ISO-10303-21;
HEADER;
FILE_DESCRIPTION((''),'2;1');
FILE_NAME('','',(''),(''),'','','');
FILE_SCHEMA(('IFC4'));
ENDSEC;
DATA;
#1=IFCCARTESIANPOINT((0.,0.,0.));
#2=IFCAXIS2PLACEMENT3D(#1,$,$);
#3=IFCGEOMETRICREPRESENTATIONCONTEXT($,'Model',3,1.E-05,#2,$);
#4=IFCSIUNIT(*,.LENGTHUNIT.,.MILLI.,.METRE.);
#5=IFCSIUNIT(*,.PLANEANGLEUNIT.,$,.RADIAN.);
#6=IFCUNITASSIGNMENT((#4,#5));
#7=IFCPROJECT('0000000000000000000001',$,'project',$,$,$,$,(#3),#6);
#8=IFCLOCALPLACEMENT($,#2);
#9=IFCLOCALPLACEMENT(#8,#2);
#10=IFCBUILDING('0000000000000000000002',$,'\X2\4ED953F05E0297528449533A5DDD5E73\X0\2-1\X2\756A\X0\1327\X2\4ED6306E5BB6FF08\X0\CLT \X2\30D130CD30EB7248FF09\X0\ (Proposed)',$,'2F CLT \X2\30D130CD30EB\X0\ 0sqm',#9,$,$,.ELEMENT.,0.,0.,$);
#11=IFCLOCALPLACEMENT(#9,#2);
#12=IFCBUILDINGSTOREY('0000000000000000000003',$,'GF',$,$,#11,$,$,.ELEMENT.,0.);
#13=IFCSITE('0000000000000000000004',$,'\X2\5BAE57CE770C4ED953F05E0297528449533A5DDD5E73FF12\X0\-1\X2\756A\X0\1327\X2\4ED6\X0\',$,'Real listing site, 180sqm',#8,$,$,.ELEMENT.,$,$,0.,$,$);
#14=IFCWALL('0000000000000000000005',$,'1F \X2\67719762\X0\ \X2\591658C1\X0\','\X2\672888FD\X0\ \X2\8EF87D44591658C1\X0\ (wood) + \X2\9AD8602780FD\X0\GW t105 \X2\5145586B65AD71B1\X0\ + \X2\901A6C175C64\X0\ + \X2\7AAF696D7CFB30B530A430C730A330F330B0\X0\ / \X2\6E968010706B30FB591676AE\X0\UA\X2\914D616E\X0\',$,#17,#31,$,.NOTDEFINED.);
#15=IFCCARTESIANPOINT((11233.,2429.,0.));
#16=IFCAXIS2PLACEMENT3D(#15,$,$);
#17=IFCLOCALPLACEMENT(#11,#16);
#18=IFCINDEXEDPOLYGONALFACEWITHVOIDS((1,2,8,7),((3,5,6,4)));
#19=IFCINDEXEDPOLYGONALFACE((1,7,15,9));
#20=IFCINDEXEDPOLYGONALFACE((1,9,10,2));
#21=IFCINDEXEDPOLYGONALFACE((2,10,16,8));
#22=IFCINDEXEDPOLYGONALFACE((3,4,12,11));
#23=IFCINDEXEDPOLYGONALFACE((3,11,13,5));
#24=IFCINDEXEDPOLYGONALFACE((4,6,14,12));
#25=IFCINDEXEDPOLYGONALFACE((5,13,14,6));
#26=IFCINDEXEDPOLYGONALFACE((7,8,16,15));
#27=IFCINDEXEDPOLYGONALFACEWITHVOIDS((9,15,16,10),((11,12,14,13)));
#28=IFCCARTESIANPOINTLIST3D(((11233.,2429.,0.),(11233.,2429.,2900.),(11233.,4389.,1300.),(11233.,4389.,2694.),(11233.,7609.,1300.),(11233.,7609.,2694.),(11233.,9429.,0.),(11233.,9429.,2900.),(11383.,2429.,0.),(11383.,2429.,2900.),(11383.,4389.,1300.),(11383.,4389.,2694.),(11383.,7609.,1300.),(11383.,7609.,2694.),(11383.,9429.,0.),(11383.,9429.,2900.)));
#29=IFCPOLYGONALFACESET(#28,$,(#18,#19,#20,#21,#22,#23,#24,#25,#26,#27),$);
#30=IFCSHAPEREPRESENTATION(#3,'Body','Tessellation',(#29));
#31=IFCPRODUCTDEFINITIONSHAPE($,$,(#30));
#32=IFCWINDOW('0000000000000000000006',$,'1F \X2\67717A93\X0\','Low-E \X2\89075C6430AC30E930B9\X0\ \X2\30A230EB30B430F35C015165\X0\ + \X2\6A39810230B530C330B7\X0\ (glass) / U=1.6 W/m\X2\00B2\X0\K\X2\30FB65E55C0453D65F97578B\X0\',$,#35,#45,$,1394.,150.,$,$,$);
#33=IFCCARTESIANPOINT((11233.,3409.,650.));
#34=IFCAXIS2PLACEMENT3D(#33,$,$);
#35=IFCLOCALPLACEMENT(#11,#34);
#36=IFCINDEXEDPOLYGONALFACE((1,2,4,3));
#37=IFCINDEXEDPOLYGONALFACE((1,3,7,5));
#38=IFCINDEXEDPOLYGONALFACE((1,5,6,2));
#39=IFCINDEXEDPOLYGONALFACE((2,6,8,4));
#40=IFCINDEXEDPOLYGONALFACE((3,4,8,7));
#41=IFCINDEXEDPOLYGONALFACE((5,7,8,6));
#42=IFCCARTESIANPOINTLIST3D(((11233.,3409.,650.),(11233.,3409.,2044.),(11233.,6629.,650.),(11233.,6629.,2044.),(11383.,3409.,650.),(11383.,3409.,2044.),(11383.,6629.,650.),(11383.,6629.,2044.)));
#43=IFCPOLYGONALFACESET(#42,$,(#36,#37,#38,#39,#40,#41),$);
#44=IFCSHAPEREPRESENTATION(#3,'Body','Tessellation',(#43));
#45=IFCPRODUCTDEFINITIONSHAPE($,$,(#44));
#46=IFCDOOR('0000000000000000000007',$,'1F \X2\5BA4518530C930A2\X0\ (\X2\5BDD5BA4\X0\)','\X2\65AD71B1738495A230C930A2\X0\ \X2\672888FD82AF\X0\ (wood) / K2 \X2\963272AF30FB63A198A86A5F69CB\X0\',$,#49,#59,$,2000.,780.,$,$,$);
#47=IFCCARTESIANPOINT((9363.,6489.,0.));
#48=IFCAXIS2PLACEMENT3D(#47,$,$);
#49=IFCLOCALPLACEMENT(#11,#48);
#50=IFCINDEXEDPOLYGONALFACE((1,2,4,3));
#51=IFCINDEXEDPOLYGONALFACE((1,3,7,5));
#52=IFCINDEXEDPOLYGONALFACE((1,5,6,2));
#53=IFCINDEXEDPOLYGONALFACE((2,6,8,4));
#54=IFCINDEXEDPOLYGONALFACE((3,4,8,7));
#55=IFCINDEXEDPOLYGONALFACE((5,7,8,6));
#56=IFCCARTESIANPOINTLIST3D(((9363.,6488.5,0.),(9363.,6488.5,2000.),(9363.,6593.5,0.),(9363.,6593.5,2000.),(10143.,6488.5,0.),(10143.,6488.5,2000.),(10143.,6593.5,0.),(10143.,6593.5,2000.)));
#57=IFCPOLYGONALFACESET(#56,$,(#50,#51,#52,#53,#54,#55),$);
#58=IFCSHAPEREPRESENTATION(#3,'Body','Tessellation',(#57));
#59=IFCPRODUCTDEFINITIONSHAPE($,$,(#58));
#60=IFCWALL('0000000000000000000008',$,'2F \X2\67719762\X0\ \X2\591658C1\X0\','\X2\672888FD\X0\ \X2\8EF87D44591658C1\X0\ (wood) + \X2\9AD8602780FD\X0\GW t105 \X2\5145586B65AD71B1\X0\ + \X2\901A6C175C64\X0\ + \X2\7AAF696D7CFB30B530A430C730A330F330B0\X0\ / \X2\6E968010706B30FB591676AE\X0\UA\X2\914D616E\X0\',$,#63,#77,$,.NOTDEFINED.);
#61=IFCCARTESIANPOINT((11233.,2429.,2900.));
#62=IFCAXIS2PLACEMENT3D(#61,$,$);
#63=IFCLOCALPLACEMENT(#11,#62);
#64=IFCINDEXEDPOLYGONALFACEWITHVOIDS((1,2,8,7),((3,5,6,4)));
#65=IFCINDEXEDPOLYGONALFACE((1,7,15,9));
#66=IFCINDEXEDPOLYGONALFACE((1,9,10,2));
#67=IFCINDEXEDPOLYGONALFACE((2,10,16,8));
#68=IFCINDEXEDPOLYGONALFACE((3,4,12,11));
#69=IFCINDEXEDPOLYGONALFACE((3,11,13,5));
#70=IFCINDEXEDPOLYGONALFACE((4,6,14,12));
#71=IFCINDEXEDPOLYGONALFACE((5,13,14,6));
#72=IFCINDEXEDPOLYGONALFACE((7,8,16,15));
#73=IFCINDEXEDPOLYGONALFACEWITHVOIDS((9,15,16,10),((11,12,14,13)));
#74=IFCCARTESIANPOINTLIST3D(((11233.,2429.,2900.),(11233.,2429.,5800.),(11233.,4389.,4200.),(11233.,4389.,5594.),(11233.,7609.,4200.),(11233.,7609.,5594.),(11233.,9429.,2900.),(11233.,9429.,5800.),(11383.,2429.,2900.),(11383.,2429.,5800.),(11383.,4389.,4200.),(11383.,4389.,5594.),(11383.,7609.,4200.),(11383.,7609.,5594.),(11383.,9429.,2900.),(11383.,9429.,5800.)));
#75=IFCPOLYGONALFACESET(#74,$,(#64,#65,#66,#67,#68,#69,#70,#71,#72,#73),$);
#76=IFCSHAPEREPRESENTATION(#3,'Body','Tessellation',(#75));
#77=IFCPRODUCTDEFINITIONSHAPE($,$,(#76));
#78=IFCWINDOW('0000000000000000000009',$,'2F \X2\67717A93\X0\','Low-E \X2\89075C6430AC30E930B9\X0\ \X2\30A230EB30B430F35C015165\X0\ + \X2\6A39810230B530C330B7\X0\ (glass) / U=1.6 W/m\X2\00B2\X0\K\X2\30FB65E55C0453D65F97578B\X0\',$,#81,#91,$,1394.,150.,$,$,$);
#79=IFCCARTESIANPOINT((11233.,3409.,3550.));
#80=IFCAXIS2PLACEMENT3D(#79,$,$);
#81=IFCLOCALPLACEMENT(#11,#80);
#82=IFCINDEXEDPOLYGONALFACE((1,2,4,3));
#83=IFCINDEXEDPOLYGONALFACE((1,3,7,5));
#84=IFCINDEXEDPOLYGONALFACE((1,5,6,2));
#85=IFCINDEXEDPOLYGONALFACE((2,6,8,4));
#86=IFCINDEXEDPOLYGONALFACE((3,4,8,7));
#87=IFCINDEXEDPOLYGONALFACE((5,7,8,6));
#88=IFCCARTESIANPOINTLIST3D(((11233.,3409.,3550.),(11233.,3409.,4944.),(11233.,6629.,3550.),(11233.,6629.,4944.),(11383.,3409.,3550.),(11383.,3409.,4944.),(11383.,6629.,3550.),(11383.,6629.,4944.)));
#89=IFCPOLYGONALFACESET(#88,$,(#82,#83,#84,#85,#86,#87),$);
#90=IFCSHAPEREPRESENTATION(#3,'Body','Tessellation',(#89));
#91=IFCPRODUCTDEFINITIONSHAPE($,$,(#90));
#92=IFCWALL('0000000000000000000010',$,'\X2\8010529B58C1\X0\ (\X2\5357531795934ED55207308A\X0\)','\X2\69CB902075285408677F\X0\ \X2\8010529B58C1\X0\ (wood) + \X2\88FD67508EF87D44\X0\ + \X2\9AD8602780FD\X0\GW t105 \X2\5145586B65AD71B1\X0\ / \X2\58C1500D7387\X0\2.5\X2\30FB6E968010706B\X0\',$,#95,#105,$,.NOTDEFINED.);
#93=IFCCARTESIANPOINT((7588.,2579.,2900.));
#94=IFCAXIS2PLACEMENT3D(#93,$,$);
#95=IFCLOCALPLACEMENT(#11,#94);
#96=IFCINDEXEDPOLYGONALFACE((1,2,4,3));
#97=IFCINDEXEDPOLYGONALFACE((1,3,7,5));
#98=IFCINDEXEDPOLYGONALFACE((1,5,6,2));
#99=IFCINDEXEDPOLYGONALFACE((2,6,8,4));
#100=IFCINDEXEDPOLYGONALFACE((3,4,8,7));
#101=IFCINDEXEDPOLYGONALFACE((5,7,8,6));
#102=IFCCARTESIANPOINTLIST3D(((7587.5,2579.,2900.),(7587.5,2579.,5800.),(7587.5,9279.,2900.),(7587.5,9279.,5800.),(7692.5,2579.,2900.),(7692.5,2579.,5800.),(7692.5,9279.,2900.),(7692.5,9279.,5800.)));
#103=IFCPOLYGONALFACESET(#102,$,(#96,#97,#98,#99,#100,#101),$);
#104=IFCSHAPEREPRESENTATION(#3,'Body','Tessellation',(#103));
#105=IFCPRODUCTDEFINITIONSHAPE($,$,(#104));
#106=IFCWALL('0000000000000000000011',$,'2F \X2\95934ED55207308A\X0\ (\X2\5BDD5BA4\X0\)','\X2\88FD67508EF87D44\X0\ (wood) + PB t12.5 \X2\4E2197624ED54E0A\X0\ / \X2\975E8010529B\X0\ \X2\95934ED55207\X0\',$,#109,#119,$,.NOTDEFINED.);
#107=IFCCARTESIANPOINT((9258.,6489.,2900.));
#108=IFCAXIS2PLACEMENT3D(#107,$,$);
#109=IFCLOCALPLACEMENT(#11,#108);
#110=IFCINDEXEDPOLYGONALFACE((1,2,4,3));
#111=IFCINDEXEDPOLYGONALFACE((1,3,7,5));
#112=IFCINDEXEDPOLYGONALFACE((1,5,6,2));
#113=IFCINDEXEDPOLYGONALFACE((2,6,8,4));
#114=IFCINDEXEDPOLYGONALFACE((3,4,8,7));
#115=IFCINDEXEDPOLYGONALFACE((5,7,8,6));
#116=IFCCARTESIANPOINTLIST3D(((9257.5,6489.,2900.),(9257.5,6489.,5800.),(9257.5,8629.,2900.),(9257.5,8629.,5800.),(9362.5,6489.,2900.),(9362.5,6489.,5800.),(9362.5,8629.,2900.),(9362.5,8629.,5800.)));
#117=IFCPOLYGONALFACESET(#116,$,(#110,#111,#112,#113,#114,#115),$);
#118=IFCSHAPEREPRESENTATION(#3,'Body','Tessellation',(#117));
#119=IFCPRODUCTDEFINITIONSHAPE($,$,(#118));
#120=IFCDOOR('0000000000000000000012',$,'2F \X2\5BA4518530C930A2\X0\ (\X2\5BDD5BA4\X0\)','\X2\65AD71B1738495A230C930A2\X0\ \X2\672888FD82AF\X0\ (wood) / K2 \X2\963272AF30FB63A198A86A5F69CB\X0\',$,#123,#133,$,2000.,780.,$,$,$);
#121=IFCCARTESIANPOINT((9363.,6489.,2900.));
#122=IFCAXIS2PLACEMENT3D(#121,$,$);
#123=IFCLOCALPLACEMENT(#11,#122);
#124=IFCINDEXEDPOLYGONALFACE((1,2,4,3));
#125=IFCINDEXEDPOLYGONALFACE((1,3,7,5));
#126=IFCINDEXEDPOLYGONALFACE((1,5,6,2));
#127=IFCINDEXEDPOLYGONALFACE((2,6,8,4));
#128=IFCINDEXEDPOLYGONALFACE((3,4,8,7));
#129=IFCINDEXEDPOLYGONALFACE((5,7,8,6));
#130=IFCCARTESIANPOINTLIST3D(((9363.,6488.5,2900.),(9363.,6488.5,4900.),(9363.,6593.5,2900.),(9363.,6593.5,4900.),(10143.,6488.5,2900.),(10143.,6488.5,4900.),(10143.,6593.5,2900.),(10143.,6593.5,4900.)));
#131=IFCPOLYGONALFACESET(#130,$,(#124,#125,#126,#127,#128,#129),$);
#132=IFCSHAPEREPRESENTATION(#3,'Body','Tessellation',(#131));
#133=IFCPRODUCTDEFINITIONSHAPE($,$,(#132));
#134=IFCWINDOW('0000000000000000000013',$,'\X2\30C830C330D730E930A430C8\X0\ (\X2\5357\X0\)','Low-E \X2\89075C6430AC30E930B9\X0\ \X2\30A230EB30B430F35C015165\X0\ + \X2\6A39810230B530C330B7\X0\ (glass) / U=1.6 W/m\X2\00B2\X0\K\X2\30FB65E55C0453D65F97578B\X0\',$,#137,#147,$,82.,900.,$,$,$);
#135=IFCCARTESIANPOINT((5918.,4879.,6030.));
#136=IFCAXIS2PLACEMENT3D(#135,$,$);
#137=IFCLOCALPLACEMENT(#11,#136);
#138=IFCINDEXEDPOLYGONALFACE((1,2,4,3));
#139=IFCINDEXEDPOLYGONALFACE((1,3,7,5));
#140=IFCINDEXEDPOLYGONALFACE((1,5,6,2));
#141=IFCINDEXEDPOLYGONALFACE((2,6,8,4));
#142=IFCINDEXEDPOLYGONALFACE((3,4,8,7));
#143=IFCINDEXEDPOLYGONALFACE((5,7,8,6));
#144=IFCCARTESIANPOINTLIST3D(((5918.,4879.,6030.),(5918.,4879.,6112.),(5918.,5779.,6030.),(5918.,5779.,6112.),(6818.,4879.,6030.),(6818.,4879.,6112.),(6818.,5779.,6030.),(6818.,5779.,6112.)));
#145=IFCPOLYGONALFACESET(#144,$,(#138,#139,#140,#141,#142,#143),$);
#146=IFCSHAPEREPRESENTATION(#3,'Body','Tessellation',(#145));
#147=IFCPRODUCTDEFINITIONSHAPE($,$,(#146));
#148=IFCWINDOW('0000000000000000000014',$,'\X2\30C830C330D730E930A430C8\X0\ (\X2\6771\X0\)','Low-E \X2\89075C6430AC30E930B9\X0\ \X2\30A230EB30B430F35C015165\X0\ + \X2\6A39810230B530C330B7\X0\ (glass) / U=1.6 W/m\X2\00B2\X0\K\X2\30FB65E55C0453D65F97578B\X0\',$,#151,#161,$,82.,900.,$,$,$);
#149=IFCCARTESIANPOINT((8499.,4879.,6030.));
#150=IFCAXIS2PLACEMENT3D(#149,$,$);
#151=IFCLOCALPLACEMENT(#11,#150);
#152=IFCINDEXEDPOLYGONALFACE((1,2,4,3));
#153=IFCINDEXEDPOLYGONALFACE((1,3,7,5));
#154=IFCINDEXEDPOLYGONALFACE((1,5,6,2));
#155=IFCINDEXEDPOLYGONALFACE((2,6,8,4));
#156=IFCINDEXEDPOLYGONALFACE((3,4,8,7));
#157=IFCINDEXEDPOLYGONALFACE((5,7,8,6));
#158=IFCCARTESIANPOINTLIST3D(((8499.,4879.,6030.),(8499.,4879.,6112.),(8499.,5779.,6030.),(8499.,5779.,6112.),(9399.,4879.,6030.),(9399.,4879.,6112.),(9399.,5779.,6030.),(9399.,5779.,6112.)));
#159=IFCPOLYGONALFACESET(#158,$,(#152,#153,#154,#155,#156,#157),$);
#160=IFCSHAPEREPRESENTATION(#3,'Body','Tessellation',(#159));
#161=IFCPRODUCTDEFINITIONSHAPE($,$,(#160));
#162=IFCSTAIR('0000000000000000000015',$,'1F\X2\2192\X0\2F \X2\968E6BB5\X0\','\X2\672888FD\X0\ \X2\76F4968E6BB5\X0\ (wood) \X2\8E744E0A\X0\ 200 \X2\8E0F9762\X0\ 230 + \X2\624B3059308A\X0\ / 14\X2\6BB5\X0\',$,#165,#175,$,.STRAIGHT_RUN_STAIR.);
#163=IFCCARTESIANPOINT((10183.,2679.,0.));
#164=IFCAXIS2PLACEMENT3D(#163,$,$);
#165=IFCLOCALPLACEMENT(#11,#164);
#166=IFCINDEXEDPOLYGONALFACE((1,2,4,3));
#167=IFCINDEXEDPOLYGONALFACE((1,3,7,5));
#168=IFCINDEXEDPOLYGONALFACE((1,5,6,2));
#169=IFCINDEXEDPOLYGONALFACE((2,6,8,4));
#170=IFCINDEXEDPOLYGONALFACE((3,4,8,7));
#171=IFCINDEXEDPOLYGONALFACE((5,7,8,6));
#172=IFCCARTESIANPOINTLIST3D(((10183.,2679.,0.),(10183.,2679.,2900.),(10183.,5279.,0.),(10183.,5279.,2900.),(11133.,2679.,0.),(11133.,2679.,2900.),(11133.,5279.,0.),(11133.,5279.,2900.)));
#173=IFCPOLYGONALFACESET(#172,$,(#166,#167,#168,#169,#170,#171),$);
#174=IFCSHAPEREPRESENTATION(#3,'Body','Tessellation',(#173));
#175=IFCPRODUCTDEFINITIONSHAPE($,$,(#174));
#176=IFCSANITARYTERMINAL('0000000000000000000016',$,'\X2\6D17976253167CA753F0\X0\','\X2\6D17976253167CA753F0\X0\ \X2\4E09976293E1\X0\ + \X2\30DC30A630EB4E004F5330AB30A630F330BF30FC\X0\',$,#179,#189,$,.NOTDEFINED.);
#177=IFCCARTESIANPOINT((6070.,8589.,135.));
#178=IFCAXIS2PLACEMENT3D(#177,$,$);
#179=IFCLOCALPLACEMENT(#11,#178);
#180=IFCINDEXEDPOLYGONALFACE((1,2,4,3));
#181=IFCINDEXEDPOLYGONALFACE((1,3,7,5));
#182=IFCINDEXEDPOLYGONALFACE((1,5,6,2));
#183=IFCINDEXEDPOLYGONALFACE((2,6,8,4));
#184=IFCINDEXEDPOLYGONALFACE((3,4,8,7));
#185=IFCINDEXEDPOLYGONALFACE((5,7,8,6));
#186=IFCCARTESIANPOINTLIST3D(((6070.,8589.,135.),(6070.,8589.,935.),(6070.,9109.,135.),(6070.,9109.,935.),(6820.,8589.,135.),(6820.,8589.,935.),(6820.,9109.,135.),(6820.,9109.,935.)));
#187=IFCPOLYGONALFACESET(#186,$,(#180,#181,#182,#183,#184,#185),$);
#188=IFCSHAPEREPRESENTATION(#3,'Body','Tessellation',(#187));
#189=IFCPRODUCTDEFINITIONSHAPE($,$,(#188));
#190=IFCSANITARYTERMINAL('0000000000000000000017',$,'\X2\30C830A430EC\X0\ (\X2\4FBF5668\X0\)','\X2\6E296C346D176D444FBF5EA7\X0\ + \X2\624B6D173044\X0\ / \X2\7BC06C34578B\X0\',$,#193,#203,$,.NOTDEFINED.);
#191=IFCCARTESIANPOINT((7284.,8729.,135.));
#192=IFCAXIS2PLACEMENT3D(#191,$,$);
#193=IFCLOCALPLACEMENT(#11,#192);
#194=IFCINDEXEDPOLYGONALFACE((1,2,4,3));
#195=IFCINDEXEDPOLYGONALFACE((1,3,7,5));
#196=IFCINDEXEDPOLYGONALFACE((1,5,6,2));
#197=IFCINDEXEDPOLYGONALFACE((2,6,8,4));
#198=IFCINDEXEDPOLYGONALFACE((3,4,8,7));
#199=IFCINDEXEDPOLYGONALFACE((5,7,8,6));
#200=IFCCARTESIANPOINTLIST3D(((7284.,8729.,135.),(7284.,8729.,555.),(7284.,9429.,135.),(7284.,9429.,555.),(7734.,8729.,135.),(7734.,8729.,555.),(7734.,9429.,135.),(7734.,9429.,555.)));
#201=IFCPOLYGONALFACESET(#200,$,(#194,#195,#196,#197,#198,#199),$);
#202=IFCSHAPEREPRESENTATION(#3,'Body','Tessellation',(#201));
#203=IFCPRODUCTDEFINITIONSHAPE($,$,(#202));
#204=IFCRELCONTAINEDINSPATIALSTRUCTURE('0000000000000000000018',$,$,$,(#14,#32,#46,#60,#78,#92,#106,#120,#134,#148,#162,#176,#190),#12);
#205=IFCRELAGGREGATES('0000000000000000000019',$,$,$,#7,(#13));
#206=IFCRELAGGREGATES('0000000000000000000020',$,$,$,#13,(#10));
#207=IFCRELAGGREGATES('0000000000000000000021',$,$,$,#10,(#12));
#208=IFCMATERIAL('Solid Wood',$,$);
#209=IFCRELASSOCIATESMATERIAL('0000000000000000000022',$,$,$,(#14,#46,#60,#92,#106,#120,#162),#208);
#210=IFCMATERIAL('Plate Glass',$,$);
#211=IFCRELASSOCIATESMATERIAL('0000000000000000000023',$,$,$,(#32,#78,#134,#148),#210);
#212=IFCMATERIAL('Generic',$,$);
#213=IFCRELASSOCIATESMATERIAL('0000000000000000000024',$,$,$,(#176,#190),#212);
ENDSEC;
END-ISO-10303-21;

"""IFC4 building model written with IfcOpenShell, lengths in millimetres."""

from ifc_helpers import new_model, si_unit, frame, frame_2d, origin, place, context, project, spatial, rectangle, extrude, material, element, fill, save


model = new_model("IFC4")

# Units and contexts
model_context = context("Model", 3, precision=1e-05, world=origin())
ifc_project = project(units=[si_unit("LENGTHUNIT", "METRE", prefix="MILLI"), si_unit("PLANEANGLEUNIT", "RADIAN")], contexts=[model_context])

# Site, building, storey
site_placement = place(None, origin())
site = spatial("IfcSite", under=ifc_project, at=site_placement, Name="宮城県仙台市青葉区川平２-1番1327他", ObjectType="Real listing site, 180sqm", CompositionType="ELEMENT", RefElevation=0.0)
building_placement = place(site_placement, origin())
building = spatial("IfcBuilding", under=site, at=building_placement, Name="仙台市青葉区川平2-1番1327他の家（CLT パネル版） (Proposed)", ObjectType="2F CLT パネル 0sqm", CompositionType="ELEMENT", ElevationOfRefHeight=0.0, ElevationOfTerrain=0.0)
storey_placement = place(building_placement, origin())
storey = spatial("IfcBuildingStorey", under=building, at=storey_placement, Name="GF", CompositionType="ELEMENT", Elevation=0.0)

# Wall, opening, window
ifc_material_1 = material(Name="Solid Wood")
wall_1_placement = place(storey_placement, frame((11233.0, 2429.0, 0.0)))
wall_1 = element("IfcWall", 1, at=wall_1_placement, inside=storey, material=ifc_material_1, Name="1F 東面 外壁", Description="木製 軸組外壁 (wood) + 高性能GW t105 充填断熱 + 通気層 + 窯業系サイディング / 準耐火・外皮UA配慮", PredefinedType="NOTDEFINED", context=model_context, shape_type="SweptSolid", body=[
    extrude(rectangle(XDim=150.0, YDim=7000.0, at=frame_2d((75.0, 3500.0))), frame((11233.0, 2429.0, 0.0)), (0.0, 0.0, 1.0), 2900.0),
])
opening_1_placement = place(storey_placement, frame((11233.0, 3409.0, 650.0)))
opening_1 = element("IfcOpeningElement", 2, at=opening_1_placement, cuts=wall_1, PredefinedType="NOTDEFINED", context=model_context, shape_type="SweptSolid", body=[
    extrude(rectangle(XDim=150.0, YDim=3220.0, at=frame_2d((75.0, 1610.0))), frame((11233.0, 3409.0, 650.0)), (0.0, 0.0, 1.0), 1394.0),
])
ifc_material_2 = material(Name="Plate Glass")
window_1_placement = place(storey_placement, frame((11233.0, 3409.0, 650.0)))
window_1 = element("IfcWindow", 3, at=window_1_placement, inside=storey, material=ifc_material_2, Name="1F 東窓", Description="Low-E 複層ガラス アルゴン封入 + 樹脂サッシ (glass) / U=1.6 W/m²K・日射取得型", OverallHeight=1394.0, OverallWidth=150.0, context=model_context, shape_type="SweptSolid", body=[
    extrude(rectangle(XDim=150.0, YDim=3220.0, at=frame_2d((75.0, 1610.0))), frame((11233.0, 3409.0, 650.0)), (0.0, 0.0, 1.0), 1394.0),
])
fill(opening_1, window_1)

# Door
door_1_placement = place(storey_placement, frame((9363.0, 6489.0, 0.0)))
element("IfcDoor", 4, at=door_1_placement, inside=storey, material=ifc_material_1, Name="1F 室内ドア (寝室)", Description="断熱玄関ドア 木製芯 (wood) / K2 防犯・採風機構", OverallHeight=2000.0, OverallWidth=780.0, context=model_context, shape_type="SweptSolid", body=[
    extrude(rectangle(XDim=780.0, YDim=105.0, at=frame_2d((390.0, 52.0))), frame((9363.0, 6489.0, 0.0)), (0.0, 0.0, 1.0), 2000.0),
])

# Wall, opening, window
wall_2_placement = place(storey_placement, frame((11233.0, 2429.0, 2900.0)))
wall_2 = element("IfcWall", 5, at=wall_2_placement, inside=storey, material=ifc_material_1, Name="2F 東面 外壁", Description="木製 軸組外壁 (wood) + 高性能GW t105 充填断熱 + 通気層 + 窯業系サイディング / 準耐火・外皮UA配慮", PredefinedType="NOTDEFINED", context=model_context, shape_type="SweptSolid", body=[
    extrude(rectangle(XDim=150.0, YDim=7000.0, at=frame_2d((75.0, 3500.0))), frame((11233.0, 2429.0, 2900.0)), (0.0, 0.0, 1.0), 2900.0),
])
opening_2_placement = place(storey_placement, frame((11233.0, 3409.0, 3550.0)))
opening_2 = element("IfcOpeningElement", 6, at=opening_2_placement, cuts=wall_2, PredefinedType="NOTDEFINED", context=model_context, shape_type="SweptSolid", body=[
    extrude(rectangle(XDim=150.0, YDim=3220.0, at=frame_2d((75.0, 1610.0))), frame((11233.0, 3409.0, 3550.0)), (0.0, 0.0, 1.0), 1394.0),
])
window_2_placement = place(storey_placement, frame((11233.0, 3409.0, 3550.0)))
window_2 = element("IfcWindow", 7, at=window_2_placement, inside=storey, material=ifc_material_2, Name="2F 東窓", Description="Low-E 複層ガラス アルゴン封入 + 樹脂サッシ (glass) / U=1.6 W/m²K・日射取得型", OverallHeight=1394.0, OverallWidth=150.0, context=model_context, shape_type="SweptSolid", body=[
    extrude(rectangle(XDim=150.0, YDim=3220.0, at=frame_2d((75.0, 1610.0))), frame((11233.0, 3409.0, 3550.0)), (0.0, 0.0, 1.0), 1394.0),
])
fill(opening_2, window_2)

# Walls
wall_3_placement = place(storey_placement, frame((7588.0, 2579.0, 2900.0)))
element("IfcWall", 8, at=wall_3_placement, inside=storey, material=ifc_material_1, Name="耐力壁 (南北間仕切り)", Description="構造用合板 耐力壁 (wood) + 製材軸組 + 高性能GW t105 充填断熱 / 壁倍率2.5・準耐火", PredefinedType="NOTDEFINED", context=model_context, shape_type="SweptSolid", body=[
    extrude(rectangle(XDim=105.0, YDim=6700.0, at=frame_2d((52.0, 3350.0))), frame((7588.0, 2579.0, 2900.0)), (0.0, 0.0, 1.0), 2900.0),
])
wall_4_placement = place(storey_placement, frame((9258.0, 6489.0, 2900.0)))
element("IfcWall", 9, at=wall_4_placement, inside=storey, material=ifc_material_1, Name="2F 間仕切り (寝室)", Description="製材軸組 (wood) + PB t12.5 両面仕上 / 非耐力 間仕切", PredefinedType="NOTDEFINED", context=model_context, shape_type="SweptSolid", body=[
    extrude(rectangle(XDim=105.0, YDim=2140.0, at=frame_2d((52.0, 1070.0))), frame((9258.0, 6489.0, 2900.0)), (0.0, 0.0, 1.0), 2900.0),
])

# Door
door_2_placement = place(storey_placement, frame((9363.0, 6489.0, 2900.0)))
element("IfcDoor", 10, at=door_2_placement, inside=storey, material=ifc_material_1, Name="2F 室内ドア (寝室)", Description="断熱玄関ドア 木製芯 (wood) / K2 防犯・採風機構", OverallHeight=2000.0, OverallWidth=780.0, context=model_context, shape_type="SweptSolid", body=[
    extrude(rectangle(XDim=780.0, YDim=105.0, at=frame_2d((390.0, 52.0))), frame((9363.0, 6489.0, 2900.0)), (0.0, 0.0, 1.0), 2000.0),
])

# Windows
window_3_placement = place(storey_placement, frame((5918.0, 4879.0, 6030.0)))
element("IfcWindow", 11, at=window_3_placement, inside=storey, material=ifc_material_2, Name="トップライト (南)", Description="Low-E 複層ガラス アルゴン封入 + 樹脂サッシ (glass) / U=1.6 W/m²K・日射取得型", OverallHeight=82.0, OverallWidth=900.0, context=model_context, shape_type="SweptSolid", body=[
    extrude(rectangle(XDim=900.0, YDim=900.0, at=frame_2d((450.0, 450.0))), frame((5918.0, 4879.0, 6030.0)), (0.0, 0.0, 1.0), 82.0),
])
window_4_placement = place(storey_placement, frame((8499.0, 4879.0, 6030.0)))
element("IfcWindow", 12, at=window_4_placement, inside=storey, material=ifc_material_2, Name="トップライト (東)", Description="Low-E 複層ガラス アルゴン封入 + 樹脂サッシ (glass) / U=1.6 W/m²K・日射取得型", OverallHeight=82.0, OverallWidth=900.0, context=model_context, shape_type="SweptSolid", body=[
    extrude(rectangle(XDim=900.0, YDim=900.0, at=frame_2d((450.0, 450.0))), frame((8499.0, 4879.0, 6030.0)), (0.0, 0.0, 1.0), 82.0),
])

# Stair
stair_placement = place(storey_placement, frame((10183.0, 2679.0, 0.0)))
element("IfcStair", 13, at=stair_placement, inside=storey, material=ifc_material_1, Name="1F→2F 階段", Description="木製 直階段 (wood) 蹴上 200 踏面 230 + 手すり / 14段", PredefinedType="STRAIGHT_RUN_STAIR", context=model_context, shape_type="SweptSolid", body=[
    extrude(rectangle(XDim=950.0, YDim=2600.0, at=frame_2d((475.0, 1300.0))), frame((10183.0, 2679.0, 0.0)), (0.0, 0.0, 1.0), 2900.0),
])

# Sanitary terminals
ifc_material_3 = material(Name="Generic")
sanitary_terminal_1_placement = place(storey_placement, frame((6070.0, 8589.0, 135.0)))
element("IfcSanitaryTerminal", 14, at=sanitary_terminal_1_placement, inside=storey, material=ifc_material_3, Name="洗面化粧台", Description="洗面化粧台 三面鏡 + ボウル一体カウンター", PredefinedType="NOTDEFINED", context=model_context, shape_type="SweptSolid", body=[
    extrude(rectangle(XDim=750.0, YDim=520.0, at=frame_2d((375.0, 260.0))), frame((6070.0, 8589.0, 135.0)), (0.0, 0.0, 1.0), 800.0),
])
sanitary_terminal_2_placement = place(storey_placement, frame((7284.0, 8729.0, 135.0)))
element("IfcSanitaryTerminal", 15, at=sanitary_terminal_2_placement, inside=storey, material=ifc_material_3, Name="トイレ (便器)", Description="温水洗浄便座 + 手洗い / 節水型", PredefinedType="NOTDEFINED", context=model_context, shape_type="SweptSolid", body=[
    extrude(rectangle(XDim=450.0, YDim=700.0, at=frame_2d((225.0, 350.0))), frame((7284.0, 8729.0, 135.0)), (0.0, 0.0, 1.0), 420.0),
])

save(model, "model.ifc")
